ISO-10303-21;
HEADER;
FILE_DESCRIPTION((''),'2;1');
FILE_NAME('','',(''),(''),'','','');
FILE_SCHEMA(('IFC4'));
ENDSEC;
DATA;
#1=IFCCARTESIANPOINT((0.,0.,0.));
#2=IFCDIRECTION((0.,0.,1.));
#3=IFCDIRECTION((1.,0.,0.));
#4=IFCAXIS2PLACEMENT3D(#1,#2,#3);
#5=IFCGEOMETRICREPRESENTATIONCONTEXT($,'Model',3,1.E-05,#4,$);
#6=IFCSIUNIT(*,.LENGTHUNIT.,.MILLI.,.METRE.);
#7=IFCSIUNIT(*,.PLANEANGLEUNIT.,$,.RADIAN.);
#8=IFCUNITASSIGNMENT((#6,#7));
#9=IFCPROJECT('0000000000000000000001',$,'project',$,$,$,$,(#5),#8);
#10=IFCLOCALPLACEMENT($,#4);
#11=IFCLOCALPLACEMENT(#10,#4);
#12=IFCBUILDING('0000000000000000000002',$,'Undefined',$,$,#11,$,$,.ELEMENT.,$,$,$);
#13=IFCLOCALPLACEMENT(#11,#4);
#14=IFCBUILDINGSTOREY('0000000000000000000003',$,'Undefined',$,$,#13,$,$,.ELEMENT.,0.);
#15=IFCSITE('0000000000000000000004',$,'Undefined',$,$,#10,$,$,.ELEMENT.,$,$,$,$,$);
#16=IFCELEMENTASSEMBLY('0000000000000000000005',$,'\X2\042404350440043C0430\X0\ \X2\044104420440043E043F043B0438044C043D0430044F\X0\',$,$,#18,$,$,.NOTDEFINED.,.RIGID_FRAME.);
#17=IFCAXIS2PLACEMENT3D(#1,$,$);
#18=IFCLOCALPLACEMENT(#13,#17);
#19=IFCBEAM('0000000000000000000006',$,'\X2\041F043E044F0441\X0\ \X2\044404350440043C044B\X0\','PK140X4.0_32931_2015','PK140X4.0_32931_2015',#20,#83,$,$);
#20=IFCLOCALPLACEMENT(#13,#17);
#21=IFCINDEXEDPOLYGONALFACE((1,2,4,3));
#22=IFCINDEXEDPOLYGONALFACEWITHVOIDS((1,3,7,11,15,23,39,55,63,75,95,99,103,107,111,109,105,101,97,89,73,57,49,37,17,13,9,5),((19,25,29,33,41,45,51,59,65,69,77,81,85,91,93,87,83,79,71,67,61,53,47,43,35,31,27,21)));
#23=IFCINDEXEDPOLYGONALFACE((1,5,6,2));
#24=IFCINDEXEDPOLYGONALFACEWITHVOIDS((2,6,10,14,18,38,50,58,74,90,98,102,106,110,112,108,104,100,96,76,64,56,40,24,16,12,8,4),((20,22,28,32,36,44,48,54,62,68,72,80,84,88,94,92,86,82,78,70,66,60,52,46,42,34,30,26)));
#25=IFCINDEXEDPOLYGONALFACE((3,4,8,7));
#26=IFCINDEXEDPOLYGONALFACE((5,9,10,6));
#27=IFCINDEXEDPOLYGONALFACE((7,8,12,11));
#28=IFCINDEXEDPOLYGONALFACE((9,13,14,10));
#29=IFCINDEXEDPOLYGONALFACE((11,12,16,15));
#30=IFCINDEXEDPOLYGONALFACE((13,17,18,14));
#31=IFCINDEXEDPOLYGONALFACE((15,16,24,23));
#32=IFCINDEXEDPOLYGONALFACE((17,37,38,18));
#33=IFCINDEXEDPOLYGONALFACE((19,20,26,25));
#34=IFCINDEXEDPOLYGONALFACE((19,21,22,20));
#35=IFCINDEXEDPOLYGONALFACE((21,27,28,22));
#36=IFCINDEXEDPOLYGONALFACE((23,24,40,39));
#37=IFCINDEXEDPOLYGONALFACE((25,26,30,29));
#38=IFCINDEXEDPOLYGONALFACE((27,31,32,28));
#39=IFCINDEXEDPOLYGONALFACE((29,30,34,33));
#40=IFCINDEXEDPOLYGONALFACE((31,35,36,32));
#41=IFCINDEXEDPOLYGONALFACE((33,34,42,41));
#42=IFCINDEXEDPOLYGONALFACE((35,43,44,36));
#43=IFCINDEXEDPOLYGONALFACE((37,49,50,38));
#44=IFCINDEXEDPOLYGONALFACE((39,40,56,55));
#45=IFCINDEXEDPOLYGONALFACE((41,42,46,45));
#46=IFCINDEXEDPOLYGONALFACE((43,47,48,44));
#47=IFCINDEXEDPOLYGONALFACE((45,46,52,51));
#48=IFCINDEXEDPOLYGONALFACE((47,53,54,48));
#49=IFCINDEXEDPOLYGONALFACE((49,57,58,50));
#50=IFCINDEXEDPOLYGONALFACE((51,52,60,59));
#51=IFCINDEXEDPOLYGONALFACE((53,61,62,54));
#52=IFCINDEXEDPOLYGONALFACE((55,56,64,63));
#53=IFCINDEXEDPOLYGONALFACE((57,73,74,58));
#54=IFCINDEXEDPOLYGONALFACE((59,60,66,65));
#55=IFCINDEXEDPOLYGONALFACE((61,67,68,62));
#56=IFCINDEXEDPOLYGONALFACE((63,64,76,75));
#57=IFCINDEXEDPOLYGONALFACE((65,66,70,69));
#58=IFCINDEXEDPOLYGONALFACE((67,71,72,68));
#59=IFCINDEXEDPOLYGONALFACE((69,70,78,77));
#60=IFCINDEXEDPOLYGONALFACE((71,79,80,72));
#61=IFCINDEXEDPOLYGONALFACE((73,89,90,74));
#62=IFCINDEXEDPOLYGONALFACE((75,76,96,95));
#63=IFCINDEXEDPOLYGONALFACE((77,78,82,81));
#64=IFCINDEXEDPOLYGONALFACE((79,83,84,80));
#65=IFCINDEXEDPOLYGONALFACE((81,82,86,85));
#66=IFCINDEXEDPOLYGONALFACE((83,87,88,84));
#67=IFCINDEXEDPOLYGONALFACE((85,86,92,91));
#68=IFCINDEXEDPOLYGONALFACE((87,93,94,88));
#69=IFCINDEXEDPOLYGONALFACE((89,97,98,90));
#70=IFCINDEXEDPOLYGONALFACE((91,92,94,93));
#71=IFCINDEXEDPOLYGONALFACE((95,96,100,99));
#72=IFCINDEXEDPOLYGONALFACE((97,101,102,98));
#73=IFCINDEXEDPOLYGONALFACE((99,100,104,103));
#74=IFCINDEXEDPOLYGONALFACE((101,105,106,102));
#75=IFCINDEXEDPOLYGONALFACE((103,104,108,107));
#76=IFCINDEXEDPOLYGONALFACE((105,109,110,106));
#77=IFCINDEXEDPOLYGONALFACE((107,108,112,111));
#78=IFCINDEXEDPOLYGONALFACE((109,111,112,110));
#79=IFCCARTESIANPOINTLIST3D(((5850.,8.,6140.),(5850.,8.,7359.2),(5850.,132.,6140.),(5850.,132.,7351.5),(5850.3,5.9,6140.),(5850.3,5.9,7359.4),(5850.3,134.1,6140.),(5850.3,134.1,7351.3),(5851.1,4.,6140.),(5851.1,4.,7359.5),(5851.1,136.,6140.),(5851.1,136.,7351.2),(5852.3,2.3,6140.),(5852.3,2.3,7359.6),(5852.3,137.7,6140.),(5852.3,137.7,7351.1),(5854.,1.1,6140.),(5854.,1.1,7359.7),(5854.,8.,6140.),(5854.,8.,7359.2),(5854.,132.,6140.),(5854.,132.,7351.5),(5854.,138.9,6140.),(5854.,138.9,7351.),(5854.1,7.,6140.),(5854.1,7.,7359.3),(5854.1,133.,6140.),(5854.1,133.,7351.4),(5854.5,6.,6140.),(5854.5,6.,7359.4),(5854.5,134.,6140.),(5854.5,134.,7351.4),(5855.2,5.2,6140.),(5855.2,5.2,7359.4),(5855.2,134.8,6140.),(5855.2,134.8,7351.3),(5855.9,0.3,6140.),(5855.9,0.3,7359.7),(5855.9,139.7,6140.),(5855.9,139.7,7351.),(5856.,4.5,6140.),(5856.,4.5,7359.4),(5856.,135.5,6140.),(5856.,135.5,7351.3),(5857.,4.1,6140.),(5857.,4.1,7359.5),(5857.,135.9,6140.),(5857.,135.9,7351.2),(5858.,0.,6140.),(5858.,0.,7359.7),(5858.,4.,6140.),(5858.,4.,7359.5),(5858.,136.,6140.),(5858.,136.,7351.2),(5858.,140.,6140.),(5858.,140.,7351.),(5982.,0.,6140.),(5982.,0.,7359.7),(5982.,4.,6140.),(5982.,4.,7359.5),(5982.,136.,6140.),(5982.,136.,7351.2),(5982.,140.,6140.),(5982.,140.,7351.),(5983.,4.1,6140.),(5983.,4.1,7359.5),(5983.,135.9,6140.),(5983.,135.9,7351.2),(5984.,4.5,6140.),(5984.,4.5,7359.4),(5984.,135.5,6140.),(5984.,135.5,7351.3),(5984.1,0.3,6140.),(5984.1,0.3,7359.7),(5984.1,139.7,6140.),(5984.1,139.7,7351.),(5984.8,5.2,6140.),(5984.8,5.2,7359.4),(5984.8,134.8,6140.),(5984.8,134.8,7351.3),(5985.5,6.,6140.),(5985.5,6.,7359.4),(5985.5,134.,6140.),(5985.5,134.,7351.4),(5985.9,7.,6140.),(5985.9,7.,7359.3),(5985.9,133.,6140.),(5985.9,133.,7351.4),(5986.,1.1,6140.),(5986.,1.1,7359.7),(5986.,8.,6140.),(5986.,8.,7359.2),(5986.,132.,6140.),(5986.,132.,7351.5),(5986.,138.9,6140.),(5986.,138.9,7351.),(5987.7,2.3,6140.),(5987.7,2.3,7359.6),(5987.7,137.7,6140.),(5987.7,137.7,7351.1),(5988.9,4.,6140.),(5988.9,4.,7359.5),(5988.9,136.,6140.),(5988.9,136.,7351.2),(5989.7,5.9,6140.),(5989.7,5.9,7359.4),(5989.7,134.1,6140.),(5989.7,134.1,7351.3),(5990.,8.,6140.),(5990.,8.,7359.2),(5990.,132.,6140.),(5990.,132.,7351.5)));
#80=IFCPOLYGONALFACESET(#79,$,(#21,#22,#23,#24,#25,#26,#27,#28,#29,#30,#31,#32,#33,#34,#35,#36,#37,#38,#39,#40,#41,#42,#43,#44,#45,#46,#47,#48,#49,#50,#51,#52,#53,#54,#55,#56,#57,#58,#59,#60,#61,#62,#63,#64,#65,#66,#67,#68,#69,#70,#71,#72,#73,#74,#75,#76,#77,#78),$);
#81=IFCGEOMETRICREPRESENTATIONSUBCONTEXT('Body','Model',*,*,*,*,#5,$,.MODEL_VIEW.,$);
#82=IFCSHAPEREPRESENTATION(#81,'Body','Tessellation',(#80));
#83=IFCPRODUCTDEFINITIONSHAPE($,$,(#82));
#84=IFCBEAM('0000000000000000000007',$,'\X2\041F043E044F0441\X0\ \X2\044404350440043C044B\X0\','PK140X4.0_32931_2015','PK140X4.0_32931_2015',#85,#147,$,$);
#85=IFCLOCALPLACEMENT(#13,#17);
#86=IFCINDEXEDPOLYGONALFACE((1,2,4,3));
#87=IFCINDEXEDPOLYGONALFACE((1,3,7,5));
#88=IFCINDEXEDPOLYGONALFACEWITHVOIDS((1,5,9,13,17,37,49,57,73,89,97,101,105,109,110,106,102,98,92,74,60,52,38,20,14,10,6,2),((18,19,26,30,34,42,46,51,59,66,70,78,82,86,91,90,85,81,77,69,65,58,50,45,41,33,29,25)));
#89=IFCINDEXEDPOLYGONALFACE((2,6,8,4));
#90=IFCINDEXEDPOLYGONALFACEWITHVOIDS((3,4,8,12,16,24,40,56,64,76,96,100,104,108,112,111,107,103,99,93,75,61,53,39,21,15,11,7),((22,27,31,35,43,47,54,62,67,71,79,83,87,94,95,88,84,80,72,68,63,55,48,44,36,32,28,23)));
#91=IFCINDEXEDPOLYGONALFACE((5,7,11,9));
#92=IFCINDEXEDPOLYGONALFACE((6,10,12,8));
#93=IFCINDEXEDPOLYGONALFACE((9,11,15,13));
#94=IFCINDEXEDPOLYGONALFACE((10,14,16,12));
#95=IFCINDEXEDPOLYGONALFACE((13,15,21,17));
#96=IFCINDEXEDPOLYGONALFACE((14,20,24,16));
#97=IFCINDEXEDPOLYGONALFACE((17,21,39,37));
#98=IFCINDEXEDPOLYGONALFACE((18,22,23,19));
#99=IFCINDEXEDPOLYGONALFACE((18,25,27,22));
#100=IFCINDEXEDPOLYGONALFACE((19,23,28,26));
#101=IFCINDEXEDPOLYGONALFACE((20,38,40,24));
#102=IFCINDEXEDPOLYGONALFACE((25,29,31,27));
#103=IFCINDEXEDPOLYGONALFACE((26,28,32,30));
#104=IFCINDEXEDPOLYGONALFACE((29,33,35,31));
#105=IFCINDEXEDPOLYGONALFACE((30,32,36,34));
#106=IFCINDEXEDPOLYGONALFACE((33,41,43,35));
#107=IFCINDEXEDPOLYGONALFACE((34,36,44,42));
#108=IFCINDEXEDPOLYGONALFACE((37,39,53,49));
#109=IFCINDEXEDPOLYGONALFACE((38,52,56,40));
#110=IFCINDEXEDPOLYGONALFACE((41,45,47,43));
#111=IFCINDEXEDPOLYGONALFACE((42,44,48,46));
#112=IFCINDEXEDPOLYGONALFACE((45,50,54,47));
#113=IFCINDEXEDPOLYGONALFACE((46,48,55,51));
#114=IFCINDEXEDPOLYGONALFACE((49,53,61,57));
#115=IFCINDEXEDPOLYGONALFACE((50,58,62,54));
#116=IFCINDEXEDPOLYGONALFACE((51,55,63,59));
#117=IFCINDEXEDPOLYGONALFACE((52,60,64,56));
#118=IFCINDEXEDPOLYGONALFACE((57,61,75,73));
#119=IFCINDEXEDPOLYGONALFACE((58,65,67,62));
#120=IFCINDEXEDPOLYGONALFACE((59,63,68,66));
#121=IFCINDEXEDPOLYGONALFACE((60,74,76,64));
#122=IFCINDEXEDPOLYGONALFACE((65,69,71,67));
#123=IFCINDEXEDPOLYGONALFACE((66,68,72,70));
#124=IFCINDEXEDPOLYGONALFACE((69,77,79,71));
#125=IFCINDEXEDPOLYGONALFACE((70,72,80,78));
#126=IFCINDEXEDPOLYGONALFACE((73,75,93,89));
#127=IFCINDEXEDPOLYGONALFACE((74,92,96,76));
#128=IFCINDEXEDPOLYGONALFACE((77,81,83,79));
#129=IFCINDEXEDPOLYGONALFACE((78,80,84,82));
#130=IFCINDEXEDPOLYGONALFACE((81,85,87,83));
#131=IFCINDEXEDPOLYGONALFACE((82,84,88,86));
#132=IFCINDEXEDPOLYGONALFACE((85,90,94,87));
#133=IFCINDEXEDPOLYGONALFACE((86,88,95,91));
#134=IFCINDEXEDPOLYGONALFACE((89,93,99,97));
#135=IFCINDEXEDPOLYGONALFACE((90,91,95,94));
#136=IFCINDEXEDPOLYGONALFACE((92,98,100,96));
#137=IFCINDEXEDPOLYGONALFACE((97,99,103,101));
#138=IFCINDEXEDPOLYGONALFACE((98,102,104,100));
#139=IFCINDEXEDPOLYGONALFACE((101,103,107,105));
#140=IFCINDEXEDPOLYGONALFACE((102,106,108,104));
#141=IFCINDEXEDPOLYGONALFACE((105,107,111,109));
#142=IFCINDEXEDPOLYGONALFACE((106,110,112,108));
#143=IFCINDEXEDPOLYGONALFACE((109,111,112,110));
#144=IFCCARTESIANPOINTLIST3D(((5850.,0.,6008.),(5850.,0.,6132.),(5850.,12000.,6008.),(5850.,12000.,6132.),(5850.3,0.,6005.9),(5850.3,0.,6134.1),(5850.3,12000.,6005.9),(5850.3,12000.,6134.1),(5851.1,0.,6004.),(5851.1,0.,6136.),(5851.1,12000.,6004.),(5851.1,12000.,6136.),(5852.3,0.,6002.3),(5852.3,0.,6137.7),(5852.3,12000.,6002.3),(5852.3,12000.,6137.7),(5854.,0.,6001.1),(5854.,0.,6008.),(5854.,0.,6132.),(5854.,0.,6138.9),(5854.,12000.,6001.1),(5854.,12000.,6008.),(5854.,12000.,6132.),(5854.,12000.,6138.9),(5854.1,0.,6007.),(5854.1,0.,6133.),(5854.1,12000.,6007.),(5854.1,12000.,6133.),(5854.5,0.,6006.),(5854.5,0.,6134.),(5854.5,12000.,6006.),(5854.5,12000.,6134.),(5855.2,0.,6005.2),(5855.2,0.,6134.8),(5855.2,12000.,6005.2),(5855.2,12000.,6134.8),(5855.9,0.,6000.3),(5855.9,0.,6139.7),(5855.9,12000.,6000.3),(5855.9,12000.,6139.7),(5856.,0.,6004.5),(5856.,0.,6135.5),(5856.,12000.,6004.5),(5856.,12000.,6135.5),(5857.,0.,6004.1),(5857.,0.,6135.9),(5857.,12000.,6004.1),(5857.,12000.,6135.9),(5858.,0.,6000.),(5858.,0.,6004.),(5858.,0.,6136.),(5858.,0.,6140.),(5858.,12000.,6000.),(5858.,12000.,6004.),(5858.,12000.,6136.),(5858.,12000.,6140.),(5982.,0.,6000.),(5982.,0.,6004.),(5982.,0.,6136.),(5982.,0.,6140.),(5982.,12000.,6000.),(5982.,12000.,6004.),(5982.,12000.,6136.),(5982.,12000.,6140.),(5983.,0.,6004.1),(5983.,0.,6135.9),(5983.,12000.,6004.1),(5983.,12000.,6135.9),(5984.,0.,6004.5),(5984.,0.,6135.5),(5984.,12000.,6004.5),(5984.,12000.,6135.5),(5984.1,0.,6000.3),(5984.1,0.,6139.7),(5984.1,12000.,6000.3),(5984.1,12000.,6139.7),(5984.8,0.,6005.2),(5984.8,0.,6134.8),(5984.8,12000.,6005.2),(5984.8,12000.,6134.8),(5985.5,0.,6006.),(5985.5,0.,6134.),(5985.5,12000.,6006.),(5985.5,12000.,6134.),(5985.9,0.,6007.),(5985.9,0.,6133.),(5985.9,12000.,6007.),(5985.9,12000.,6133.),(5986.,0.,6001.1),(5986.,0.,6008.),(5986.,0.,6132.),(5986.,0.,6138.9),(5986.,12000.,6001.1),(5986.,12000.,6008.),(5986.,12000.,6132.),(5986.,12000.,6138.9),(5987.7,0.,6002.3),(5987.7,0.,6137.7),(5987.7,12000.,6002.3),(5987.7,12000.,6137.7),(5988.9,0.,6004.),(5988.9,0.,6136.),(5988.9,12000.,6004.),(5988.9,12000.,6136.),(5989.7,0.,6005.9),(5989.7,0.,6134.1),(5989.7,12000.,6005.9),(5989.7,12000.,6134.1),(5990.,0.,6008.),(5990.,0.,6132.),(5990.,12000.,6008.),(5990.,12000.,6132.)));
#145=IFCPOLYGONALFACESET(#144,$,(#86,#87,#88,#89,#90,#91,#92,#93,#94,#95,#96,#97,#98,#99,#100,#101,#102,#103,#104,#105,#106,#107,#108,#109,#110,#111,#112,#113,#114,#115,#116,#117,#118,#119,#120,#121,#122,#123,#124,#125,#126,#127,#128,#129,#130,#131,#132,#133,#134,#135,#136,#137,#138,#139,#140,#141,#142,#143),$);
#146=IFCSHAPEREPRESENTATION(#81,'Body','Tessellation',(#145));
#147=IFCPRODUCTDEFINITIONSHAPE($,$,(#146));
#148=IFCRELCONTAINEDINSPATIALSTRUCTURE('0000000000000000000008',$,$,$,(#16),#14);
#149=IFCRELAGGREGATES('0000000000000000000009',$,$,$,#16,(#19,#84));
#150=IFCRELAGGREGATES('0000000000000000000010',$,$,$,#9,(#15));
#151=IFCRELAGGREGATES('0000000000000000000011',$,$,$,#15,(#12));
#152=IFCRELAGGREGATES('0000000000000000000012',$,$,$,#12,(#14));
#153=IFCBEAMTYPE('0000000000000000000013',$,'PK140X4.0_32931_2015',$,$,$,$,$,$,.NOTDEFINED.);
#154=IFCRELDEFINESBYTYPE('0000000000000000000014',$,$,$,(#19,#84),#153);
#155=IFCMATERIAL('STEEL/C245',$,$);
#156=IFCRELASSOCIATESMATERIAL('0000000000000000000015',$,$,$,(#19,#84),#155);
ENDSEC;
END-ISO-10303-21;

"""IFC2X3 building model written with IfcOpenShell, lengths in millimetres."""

from ifc_helpers import new_model, si_unit, frame, origin_with_axes, origin_2d_with_axis, place, context, subcontext, project, spatial, hollow_rectangle, extrude, clip, halfspace, material, type_object, element, aggregate, save


model = new_model("IFC2X3")

# Units and contexts
model_context = context("Model", 3, precision=1e-05, world=origin_with_axes())
body_context = subcontext(model_context, "Body", "Model", "MODEL_VIEW")
ifc_project = project(units=[si_unit("LENGTHUNIT", "METRE", prefix="MILLI"), si_unit("PLANEANGLEUNIT", "RADIAN")], contexts=[model_context])

# Site, building, storey
site_placement = place(None, origin_with_axes())
site = spatial("IfcSite", under=ifc_project, at=site_placement, Name="Undefined", CompositionType="ELEMENT")
building_placement = place(site_placement, origin_with_axes())
building = spatial("IfcBuilding", under=site, at=building_placement, Name="Undefined", CompositionType="ELEMENT")
storey_placement = place(building_placement, origin_with_axes())
storey = spatial("IfcBuildingStorey", under=building, at=storey_placement, Name="Undefined", CompositionType="ELEMENT", Elevation=0.0)

# Shared definitions
ifc_material = material(Name="STEEL/C245")

# Element assembly, beams
assembly_1_placement = place(storey_placement, origin_with_axes())
assembly_1 = element("IfcElementAssembly", 1, at=assembly_1_placement, inside=storey, Name="Ферма строплиьная", AssemblyPlace="NOTDEFINED", PredefinedType="RIGID_FRAME")
beam_type_1 = type_object("IfcBeamType", Name="PK140X4.0_32931_2015", PredefinedType="NOTDEFINED")
beam_1_placement = place(assembly_1_placement, frame((5920.0, 70.0, 7359.7), z_axis=(1.0, 0.0, 0.0), x_axis=(0.0, 0.0, -1.0)))
beam_1 = element("IfcBeam", 2, at=beam_1_placement, type_object=beam_type_1, material=ifc_material, Name="Пояс фермы", Description="PK140X4.0_32931_2015", ObjectType="PK140X4.0_32931_2015", context=body_context, shape_type="Clipping", body=[
    clip(extrude(hollow_rectangle(XDim=140.0, YDim=140.0, WallThickness=4.0, InnerFilletRadius=4.0, OuterFilletRadius=8.0, at=origin_2d_with_axis()), frame((1219.7, 0.0, 0.0), z_axis=(-1.0, 0.0, 0.0), x_axis=(0.0, -1.0, 0.0)), (0.0, 0.0, 1.0), 1219.8), halfspace(frame((10.5, 98.4, 0.0), z_axis=(0.998053, -0.062378, 0.0), x_axis=(0.0, 0.0, 1.0)), True)),
])
beam_2_placement = place(assembly_1_placement, frame((5920.0, 0.0, 6070.0), z_axis=(0.0, 0.0, 1.0), x_axis=(0.0, 1.0, 0.0)))
beam_2 = element("IfcBeam", 3, at=beam_2_placement, type_object=beam_type_1, material=ifc_material, Name="Пояс фермы", Description="PK140X4.0_32931_2015", ObjectType="PK140X4.0_32931_2015", context=body_context, shape_type="SweptSolid", body=[
    extrude(hollow_rectangle(XDim=140.0, YDim=140.0, WallThickness=4.0, InnerFilletRadius=4.0, OuterFilletRadius=8.0, at=origin_2d_with_axis()), frame((12000.0, 0.0, 0.0), z_axis=(-1.0, 0.0, 0.0), x_axis=(0.0, -1.0, 0.0)), (0.0, 0.0, 1.0), 12000.0),
])
aggregate(assembly_1, [beam_1, beam_2])

save(model, "model.ifc")
